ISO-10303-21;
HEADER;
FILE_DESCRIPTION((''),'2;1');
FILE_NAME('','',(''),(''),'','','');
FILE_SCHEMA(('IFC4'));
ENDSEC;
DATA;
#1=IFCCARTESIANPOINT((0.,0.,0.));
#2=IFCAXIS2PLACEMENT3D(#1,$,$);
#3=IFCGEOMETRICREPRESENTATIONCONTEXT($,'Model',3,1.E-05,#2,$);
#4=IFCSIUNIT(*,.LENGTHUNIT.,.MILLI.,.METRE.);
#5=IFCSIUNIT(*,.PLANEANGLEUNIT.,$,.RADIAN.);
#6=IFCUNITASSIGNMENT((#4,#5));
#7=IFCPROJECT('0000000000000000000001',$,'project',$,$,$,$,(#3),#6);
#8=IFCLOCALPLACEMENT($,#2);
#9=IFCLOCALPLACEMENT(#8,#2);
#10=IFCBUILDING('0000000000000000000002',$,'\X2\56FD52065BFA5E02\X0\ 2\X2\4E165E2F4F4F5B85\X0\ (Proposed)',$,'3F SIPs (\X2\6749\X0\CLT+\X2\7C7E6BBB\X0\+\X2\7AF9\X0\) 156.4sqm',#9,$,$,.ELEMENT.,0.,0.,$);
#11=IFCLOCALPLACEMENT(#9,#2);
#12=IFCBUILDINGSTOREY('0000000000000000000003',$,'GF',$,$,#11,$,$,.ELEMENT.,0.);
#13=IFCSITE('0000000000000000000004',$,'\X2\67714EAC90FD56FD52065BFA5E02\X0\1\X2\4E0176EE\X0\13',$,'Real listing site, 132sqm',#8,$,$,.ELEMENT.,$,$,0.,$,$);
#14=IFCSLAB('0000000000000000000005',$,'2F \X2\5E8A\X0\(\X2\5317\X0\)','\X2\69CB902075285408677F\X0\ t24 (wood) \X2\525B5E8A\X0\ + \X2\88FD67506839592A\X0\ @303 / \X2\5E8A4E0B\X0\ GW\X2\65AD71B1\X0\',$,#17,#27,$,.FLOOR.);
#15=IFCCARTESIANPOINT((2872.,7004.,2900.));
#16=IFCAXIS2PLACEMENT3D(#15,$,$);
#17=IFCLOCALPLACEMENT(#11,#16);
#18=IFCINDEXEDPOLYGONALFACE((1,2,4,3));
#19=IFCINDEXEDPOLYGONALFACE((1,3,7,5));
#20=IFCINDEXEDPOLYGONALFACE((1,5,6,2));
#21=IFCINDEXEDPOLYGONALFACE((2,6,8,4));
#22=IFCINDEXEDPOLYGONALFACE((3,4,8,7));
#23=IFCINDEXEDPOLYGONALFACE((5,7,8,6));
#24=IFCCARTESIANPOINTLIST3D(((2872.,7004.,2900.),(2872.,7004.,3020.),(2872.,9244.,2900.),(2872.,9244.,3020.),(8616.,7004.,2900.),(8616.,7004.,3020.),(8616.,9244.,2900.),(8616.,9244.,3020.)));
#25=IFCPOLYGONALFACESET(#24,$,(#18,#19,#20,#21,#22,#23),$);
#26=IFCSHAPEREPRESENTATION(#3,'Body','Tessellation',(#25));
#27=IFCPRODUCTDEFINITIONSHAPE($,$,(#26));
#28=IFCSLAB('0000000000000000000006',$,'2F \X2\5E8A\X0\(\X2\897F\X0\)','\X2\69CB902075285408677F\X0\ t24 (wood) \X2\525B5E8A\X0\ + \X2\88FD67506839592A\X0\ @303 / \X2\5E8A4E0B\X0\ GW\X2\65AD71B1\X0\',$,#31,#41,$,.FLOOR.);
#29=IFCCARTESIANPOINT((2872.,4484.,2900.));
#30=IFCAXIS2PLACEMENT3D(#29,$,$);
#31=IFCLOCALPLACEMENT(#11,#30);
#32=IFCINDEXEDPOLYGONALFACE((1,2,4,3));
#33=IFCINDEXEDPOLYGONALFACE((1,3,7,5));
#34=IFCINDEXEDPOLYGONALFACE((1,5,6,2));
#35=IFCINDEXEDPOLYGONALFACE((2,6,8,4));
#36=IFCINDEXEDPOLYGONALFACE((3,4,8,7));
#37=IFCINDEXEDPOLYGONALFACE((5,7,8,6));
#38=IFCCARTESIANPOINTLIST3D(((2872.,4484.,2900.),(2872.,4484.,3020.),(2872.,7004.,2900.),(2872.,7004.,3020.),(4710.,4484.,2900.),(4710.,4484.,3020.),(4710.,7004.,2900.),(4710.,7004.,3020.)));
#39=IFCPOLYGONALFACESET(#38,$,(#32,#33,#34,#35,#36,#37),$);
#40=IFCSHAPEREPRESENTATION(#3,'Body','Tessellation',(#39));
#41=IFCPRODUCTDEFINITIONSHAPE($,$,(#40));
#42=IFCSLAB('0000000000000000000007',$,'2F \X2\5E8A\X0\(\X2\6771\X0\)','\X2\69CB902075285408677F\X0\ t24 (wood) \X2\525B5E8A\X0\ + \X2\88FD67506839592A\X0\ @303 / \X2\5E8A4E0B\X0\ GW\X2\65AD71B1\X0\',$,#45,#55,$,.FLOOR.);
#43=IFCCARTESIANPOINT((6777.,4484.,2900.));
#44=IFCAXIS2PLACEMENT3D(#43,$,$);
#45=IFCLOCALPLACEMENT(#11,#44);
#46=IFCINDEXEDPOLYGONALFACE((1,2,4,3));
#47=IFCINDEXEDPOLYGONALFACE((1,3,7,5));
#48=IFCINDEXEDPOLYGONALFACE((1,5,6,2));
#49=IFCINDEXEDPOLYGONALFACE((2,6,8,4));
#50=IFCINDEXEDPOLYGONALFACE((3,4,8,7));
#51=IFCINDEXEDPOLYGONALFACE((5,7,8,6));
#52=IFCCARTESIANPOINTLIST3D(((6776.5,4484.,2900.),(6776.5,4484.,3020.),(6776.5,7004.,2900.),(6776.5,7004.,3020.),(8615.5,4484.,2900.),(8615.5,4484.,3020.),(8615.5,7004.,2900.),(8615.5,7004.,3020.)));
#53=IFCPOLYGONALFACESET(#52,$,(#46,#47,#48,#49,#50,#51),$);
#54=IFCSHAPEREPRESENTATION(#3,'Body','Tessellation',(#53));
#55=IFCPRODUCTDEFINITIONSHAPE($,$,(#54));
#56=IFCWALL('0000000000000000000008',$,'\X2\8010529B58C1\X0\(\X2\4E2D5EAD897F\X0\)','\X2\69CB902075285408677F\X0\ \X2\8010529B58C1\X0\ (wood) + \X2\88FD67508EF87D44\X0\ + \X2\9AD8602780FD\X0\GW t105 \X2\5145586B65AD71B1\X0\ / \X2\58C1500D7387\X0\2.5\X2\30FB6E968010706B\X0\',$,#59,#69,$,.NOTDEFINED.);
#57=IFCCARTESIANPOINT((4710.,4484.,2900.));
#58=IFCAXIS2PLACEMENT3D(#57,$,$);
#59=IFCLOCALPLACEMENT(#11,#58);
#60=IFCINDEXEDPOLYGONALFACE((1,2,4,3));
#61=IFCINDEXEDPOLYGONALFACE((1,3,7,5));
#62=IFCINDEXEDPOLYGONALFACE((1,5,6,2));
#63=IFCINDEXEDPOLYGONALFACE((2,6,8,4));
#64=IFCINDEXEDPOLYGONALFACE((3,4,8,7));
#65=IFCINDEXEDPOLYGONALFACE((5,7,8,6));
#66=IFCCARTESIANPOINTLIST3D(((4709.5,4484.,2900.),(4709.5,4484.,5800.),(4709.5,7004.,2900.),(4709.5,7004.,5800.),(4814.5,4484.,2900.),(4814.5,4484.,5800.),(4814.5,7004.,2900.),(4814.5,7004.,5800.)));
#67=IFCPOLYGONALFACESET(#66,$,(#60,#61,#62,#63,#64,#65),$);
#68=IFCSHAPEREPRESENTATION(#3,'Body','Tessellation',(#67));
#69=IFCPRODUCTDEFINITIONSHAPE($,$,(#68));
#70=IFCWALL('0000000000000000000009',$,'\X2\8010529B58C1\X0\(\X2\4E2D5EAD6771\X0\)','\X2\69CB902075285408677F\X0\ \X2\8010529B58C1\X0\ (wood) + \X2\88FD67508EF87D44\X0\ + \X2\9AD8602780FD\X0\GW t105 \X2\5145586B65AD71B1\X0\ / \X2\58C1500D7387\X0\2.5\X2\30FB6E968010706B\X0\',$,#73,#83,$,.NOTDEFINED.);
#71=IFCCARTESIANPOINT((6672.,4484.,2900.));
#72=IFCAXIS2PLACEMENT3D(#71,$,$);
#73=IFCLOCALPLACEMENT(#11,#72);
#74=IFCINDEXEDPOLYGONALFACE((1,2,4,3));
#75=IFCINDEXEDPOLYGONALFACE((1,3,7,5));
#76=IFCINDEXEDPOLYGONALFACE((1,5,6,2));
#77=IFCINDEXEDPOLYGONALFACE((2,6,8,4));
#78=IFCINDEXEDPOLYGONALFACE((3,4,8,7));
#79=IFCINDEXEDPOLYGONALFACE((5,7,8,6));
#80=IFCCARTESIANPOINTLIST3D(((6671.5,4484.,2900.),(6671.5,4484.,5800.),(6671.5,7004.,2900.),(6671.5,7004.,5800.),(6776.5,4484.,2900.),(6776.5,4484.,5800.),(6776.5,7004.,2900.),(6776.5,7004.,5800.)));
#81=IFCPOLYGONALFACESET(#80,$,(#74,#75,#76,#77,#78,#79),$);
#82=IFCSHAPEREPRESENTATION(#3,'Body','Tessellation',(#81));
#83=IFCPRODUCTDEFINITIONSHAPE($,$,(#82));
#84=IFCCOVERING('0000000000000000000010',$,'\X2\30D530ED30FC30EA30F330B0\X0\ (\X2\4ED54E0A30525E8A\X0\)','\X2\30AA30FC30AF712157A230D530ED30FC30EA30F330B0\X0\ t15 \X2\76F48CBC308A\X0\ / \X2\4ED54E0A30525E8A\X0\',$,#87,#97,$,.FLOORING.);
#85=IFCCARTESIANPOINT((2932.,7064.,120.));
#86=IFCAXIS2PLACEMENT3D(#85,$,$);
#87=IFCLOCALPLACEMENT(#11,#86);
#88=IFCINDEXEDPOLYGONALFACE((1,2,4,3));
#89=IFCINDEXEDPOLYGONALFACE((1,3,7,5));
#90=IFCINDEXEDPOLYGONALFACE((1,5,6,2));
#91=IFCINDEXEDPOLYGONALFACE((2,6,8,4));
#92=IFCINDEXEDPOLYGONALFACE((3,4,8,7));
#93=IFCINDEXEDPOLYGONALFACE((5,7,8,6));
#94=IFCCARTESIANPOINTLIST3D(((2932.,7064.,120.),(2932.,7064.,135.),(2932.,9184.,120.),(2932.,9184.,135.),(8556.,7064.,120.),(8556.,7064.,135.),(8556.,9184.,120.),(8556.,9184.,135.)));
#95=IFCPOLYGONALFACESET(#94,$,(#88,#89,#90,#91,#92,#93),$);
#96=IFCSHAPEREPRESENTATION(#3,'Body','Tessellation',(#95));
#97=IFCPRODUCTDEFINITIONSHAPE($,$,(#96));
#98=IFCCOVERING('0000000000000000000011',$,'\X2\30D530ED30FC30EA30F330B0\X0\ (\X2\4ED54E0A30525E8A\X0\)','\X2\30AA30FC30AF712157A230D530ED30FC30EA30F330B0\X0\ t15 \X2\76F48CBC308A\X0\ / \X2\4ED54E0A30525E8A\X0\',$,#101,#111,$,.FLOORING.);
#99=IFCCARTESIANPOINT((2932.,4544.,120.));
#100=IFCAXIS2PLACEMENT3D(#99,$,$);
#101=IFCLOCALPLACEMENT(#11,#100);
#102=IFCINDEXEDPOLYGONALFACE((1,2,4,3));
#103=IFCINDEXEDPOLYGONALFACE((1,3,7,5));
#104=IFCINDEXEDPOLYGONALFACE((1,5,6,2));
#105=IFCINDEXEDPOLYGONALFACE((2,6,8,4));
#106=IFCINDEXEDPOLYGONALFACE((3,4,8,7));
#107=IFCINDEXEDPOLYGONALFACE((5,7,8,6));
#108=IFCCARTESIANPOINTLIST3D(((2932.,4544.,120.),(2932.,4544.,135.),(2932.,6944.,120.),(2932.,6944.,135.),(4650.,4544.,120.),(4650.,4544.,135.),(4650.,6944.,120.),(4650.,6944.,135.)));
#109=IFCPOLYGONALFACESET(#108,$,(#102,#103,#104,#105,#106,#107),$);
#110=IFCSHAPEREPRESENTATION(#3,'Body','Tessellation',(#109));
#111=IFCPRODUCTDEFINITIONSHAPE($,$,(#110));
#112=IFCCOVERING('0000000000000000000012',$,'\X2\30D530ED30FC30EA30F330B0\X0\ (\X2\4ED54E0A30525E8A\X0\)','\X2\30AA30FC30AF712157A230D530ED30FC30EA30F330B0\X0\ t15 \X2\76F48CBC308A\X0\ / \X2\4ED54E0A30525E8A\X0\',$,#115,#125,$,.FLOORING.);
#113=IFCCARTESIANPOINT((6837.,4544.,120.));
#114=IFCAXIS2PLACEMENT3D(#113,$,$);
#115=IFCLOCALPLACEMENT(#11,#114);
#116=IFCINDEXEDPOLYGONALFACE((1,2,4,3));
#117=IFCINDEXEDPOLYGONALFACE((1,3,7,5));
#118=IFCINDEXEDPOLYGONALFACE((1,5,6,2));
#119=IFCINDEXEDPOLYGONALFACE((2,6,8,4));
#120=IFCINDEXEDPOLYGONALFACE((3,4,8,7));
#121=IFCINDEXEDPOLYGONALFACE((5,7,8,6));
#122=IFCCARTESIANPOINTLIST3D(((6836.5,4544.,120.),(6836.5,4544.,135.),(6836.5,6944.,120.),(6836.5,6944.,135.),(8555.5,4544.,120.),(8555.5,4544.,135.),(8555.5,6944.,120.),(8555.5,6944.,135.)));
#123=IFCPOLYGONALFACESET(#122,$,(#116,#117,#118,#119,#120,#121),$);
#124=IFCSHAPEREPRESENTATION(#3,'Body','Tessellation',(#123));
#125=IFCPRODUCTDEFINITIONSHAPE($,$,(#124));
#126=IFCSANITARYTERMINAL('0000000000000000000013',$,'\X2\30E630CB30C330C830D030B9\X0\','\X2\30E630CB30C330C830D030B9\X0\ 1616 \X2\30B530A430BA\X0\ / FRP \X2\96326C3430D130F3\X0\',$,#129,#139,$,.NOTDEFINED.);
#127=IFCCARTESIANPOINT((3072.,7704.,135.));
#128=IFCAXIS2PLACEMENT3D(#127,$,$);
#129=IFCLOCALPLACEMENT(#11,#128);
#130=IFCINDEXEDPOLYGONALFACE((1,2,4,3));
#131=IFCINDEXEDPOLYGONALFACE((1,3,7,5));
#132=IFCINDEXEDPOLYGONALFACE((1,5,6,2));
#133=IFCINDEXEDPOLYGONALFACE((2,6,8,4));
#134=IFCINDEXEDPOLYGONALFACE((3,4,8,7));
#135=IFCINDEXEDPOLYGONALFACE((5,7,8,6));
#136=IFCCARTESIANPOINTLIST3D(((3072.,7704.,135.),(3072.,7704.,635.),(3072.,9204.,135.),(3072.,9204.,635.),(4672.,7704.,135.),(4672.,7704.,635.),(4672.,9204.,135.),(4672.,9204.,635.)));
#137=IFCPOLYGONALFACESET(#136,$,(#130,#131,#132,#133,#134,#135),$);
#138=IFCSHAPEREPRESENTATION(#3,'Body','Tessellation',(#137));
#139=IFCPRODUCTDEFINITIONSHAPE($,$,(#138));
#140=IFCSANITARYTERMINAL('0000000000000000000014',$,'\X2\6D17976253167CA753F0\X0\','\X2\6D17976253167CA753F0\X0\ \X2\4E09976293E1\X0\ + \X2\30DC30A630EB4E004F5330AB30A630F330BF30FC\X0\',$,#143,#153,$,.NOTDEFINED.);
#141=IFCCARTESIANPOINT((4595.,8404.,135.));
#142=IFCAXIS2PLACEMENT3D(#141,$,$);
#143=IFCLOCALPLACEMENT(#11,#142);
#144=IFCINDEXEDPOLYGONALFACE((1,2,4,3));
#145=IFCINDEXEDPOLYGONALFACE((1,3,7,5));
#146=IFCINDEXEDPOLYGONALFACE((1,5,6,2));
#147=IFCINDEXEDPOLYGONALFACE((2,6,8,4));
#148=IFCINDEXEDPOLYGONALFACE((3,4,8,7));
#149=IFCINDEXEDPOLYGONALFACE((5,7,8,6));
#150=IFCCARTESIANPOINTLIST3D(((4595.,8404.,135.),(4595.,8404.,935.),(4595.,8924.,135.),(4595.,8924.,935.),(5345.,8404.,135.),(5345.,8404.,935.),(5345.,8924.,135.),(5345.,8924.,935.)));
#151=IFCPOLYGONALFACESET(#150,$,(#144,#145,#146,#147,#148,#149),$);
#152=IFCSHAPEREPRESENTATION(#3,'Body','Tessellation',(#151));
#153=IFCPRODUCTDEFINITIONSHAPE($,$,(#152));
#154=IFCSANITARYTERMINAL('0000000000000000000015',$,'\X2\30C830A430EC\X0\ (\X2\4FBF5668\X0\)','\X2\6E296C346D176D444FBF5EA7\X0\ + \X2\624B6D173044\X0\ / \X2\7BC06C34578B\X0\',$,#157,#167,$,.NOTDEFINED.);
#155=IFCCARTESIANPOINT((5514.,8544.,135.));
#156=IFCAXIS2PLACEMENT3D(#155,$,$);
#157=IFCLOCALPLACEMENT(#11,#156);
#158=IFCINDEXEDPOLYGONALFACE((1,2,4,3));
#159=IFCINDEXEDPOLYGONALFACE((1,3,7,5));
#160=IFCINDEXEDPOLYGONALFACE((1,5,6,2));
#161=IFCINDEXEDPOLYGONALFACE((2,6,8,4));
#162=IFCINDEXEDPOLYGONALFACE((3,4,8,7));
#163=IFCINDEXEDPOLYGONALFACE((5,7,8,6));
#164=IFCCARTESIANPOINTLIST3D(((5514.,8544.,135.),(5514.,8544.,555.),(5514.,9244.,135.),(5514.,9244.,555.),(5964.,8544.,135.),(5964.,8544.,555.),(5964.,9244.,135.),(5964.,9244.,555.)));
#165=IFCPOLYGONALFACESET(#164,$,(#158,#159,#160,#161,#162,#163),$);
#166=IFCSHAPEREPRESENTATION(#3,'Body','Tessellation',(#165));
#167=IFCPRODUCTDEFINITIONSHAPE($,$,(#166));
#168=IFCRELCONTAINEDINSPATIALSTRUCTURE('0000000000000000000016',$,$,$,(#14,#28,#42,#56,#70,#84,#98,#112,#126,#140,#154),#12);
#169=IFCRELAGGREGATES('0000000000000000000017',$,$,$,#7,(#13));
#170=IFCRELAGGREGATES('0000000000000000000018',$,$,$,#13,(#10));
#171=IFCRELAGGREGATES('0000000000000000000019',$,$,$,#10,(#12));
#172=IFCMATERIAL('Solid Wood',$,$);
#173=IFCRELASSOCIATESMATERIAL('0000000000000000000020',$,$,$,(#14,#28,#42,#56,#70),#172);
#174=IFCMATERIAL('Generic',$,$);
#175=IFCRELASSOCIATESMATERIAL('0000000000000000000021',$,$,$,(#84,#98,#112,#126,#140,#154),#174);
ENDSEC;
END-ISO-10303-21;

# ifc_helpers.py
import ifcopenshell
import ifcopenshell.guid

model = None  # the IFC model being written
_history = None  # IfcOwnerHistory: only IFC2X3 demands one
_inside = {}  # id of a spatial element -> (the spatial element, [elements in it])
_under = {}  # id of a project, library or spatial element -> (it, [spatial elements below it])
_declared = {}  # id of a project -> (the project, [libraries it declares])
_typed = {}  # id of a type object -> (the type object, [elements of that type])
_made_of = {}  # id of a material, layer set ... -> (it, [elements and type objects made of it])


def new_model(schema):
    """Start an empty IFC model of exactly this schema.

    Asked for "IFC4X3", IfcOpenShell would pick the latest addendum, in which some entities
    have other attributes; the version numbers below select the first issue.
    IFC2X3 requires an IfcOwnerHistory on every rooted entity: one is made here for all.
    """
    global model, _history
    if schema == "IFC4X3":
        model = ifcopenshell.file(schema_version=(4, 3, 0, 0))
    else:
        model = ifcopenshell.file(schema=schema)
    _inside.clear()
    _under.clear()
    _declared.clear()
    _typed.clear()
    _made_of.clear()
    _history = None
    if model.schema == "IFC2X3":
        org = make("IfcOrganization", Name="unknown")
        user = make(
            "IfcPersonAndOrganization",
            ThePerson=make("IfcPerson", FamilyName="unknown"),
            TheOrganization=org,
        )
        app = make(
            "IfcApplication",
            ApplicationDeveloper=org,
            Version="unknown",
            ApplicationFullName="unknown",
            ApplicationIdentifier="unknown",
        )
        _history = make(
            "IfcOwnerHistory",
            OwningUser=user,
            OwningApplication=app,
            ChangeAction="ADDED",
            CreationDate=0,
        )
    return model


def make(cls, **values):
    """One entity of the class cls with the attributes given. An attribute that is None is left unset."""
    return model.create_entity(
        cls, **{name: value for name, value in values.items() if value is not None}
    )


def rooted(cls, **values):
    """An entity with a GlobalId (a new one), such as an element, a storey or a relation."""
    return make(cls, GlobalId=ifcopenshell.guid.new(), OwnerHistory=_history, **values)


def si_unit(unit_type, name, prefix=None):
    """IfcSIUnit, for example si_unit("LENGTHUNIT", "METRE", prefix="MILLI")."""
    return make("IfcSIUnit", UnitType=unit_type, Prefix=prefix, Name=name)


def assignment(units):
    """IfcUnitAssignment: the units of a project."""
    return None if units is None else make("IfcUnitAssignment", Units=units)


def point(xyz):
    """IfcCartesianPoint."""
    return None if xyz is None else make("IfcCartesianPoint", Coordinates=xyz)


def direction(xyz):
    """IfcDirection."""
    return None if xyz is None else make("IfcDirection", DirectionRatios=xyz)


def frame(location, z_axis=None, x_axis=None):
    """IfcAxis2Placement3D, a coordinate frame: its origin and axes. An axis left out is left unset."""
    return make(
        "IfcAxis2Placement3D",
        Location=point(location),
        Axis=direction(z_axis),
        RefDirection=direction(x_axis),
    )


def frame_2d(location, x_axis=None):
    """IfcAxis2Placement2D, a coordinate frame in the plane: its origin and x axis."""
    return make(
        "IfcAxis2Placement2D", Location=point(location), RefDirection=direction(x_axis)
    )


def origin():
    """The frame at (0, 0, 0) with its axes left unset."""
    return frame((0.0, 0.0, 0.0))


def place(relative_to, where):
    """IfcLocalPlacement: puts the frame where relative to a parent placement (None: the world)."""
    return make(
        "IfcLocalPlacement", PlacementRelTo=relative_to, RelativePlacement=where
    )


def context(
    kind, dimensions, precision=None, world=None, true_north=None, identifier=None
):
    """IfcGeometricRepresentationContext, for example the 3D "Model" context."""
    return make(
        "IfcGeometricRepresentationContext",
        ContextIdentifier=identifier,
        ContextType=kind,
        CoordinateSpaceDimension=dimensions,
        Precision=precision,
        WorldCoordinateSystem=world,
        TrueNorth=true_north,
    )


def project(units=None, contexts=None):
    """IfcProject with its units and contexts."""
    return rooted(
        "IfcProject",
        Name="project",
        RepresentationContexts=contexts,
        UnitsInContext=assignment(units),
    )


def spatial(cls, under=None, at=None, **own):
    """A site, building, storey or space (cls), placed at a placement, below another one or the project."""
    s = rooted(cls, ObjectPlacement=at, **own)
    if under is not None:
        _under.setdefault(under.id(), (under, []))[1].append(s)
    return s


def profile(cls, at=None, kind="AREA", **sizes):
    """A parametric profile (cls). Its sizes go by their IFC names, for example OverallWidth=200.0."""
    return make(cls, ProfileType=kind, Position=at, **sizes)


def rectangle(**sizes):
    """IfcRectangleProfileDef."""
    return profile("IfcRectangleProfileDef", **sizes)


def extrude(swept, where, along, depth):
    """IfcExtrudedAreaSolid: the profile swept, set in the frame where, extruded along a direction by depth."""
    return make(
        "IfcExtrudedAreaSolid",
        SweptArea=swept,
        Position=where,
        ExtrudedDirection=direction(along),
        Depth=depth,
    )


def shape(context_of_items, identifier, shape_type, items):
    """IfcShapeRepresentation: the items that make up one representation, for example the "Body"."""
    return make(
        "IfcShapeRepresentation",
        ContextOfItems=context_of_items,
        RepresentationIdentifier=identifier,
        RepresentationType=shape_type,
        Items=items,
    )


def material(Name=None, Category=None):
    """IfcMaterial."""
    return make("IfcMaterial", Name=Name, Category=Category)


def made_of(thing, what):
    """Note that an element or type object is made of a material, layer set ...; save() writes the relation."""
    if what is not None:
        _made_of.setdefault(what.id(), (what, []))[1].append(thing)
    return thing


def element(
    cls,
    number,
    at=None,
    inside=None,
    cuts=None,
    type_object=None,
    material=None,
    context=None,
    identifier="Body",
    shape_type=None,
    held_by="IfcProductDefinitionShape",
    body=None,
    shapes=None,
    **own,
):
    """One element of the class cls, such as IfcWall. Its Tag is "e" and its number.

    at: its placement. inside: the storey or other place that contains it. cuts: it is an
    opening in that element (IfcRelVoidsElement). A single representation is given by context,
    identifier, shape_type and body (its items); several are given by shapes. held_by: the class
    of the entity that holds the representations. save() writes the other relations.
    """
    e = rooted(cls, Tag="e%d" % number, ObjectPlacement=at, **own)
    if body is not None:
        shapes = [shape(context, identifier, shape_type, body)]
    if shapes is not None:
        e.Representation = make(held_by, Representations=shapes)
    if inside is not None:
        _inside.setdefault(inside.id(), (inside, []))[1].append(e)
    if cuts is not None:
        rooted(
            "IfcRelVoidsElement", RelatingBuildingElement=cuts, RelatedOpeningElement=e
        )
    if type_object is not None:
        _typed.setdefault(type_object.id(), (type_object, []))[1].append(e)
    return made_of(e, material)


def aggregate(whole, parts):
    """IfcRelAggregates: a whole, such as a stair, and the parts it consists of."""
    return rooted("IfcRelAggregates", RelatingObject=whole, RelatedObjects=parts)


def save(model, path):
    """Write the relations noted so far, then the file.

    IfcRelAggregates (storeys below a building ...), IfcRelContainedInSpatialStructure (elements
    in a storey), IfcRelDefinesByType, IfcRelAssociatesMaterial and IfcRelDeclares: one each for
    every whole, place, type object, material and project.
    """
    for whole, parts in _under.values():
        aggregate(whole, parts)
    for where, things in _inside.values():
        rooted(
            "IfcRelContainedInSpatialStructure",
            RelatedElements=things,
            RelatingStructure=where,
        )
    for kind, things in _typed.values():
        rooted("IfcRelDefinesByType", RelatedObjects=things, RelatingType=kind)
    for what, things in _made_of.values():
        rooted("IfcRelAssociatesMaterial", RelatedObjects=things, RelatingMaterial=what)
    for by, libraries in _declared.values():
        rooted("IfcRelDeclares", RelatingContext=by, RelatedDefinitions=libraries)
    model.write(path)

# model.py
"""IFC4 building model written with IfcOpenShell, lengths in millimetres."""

from ifc_helpers import new_model, si_unit, frame, frame_2d, origin, place, context, project, spatial, rectangle, extrude, material, element, save


model = new_model("IFC4")

# Units and contexts
model_context = context("Model", 3, precision=1e-05, world=origin())
ifc_project = project(units=[si_unit("LENGTHUNIT", "METRE", prefix="MILLI"), si_unit("PLANEANGLEUNIT", "RADIAN")], contexts=[model_context])

# Site, building, storey
site_placement = place(None, origin())
site = spatial("IfcSite", under=ifc_project, at=site_placement, Name="東京都国分寺市1丁目13", ObjectType="Real listing site, 132sqm", CompositionType="ELEMENT", RefElevation=0.0)
building_placement = place(site_placement, origin())
building = spatial("IfcBuilding", under=site, at=building_placement, Name="国分寺市 2世帯住宅 (Proposed)", ObjectType="3F SIPs (杉CLT+籾殻+竹) 156.4sqm", CompositionType="ELEMENT", ElevationOfRefHeight=0.0, ElevationOfTerrain=0.0)
storey_placement = place(building_placement, origin())
storey = spatial("IfcBuildingStorey", under=building, at=storey_placement, Name="GF", CompositionType="ELEMENT", Elevation=0.0)

# Slabs
ifc_material_1 = material(Name="Solid Wood")
slab_1_placement = place(storey_placement, frame((2872.0, 7004.0, 2900.0)))
element("IfcSlab", 1, at=slab_1_placement, inside=storey, material=ifc_material_1, Name="2F 床(北)", Description="構造用合板 t24 (wood) 剛床 + 製材根太 @303 / 床下 GW断熱", PredefinedType="FLOOR", context=model_context, shape_type="SweptSolid", body=[
    extrude(rectangle(XDim=5744.0, YDim=2240.0, at=frame_2d((2872.0, 1120.0))), frame((2872.0, 7004.0, 2900.0)), (0.0, 0.0, 1.0), 120.0),
])
slab_2_placement = place(storey_placement, frame((2872.0, 4484.0, 2900.0)))
element("IfcSlab", 2, at=slab_2_placement, inside=storey, material=ifc_material_1, Name="2F 床(西)", Description="構造用合板 t24 (wood) 剛床 + 製材根太 @303 / 床下 GW断熱", PredefinedType="FLOOR", context=model_context, shape_type="SweptSolid", body=[
    extrude(rectangle(XDim=1838.0, YDim=2520.0, at=frame_2d((919.0, 1260.0))), frame((2872.0, 4484.0, 2900.0)), (0.0, 0.0, 1.0), 120.0),
])
slab_3_placement = place(storey_placement, frame((6777.0, 4484.0, 2900.0)))
element("IfcSlab", 3, at=slab_3_placement, inside=storey, material=ifc_material_1, Name="2F 床(東)", Description="構造用合板 t24 (wood) 剛床 + 製材根太 @303 / 床下 GW断熱", PredefinedType="FLOOR", context=model_context, shape_type="SweptSolid", body=[
    extrude(rectangle(XDim=1839.0, YDim=2520.0, at=frame_2d((919.0, 1260.0))), frame((6777.0, 4484.0, 2900.0)), (0.0, 0.0, 1.0), 120.0),
])

# Walls
wall_1_placement = place(storey_placement, frame((4710.0, 4484.0, 2900.0)))
element("IfcWall", 4, at=wall_1_placement, inside=storey, material=ifc_material_1, Name="耐力壁(中庭西)", Description="構造用合板 耐力壁 (wood) + 製材軸組 + 高性能GW t105 充填断熱 / 壁倍率2.5・準耐火", PredefinedType="NOTDEFINED", context=model_context, shape_type="SweptSolid", body=[
    extrude(rectangle(XDim=105.0, YDim=2520.0, at=frame_2d((52.0, 1260.0))), frame((4710.0, 4484.0, 2900.0)), (0.0, 0.0, 1.0), 2900.0),
])
wall_2_placement = place(storey_placement, frame((6672.0, 4484.0, 2900.0)))
element("IfcWall", 5, at=wall_2_placement, inside=storey, material=ifc_material_1, Name="耐力壁(中庭東)", Description="構造用合板 耐力壁 (wood) + 製材軸組 + 高性能GW t105 充填断熱 / 壁倍率2.5・準耐火", PredefinedType="NOTDEFINED", context=model_context, shape_type="SweptSolid", body=[
    extrude(rectangle(XDim=105.0, YDim=2520.0, at=frame_2d((52.0, 1260.0))), frame((6672.0, 4484.0, 2900.0)), (0.0, 0.0, 1.0), 2900.0),
])

# Coverings
ifc_material_2 = material(Name="Generic")
covering_1_placement = place(storey_placement, frame((2932.0, 7064.0, 120.0)))
element("IfcCovering", 6, at=covering_1_placement, inside=storey, material=ifc_material_2, Name="フローリング (仕上げ床)", Description="オーク無垢フローリング t15 直貼り / 仕上げ床", PredefinedType="FLOORING", context=model_context, shape_type="SweptSolid", body=[
    extrude(rectangle(XDim=5624.0, YDim=2120.0, at=frame_2d((2812.0, 1060.0))), frame((2932.0, 7064.0, 120.0)), (0.0, 0.0, 1.0), 15.0),
])
covering_2_placement = place(storey_placement, frame((2932.0, 4544.0, 120.0)))
element("IfcCovering", 7, at=covering_2_placement, inside=storey, material=ifc_material_2, Name="フローリング (仕上げ床)", Description="オーク無垢フローリング t15 直貼り / 仕上げ床", PredefinedType="FLOORING", context=model_context, shape_type="SweptSolid", body=[
    extrude(rectangle(XDim=1718.0, YDim=2400.0, at=frame_2d((859.0, 1200.0))), frame((2932.0, 4544.0, 120.0)), (0.0, 0.0, 1.0), 15.0),
])
covering_3_placement = place(storey_placement, frame((6837.0, 4544.0, 120.0)))
element("IfcCovering", 8, at=covering_3_placement, inside=storey, material=ifc_material_2, Name="フローリング (仕上げ床)", Description="オーク無垢フローリング t15 直貼り / 仕上げ床", PredefinedType="FLOORING", context=model_context, shape_type="SweptSolid", body=[
    extrude(rectangle(XDim=1719.0, YDim=2400.0, at=frame_2d((859.0, 1200.0))), frame((6837.0, 4544.0, 120.0)), (0.0, 0.0, 1.0), 15.0),
])

# Sanitary terminals
sanitary_terminal_1_placement = place(storey_placement, frame((3072.0, 7704.0, 135.0)))
element("IfcSanitaryTerminal", 9, at=sanitary_terminal_1_placement, inside=storey, material=ifc_material_2, Name="ユニットバス", Description="ユニットバス 1616 サイズ / FRP 防水パン", PredefinedType="NOTDEFINED", context=model_context, shape_type="SweptSolid", body=[
    extrude(rectangle(XDim=1600.0, YDim=1500.0, at=frame_2d((800.0, 750.0))), frame((3072.0, 7704.0, 135.0)), (0.0, 0.0, 1.0), 500.0),
])
sanitary_terminal_2_placement = place(storey_placement, frame((4595.0, 8404.0, 135.0)))
element("IfcSanitaryTerminal", 10, at=sanitary_terminal_2_placement, inside=storey, material=ifc_material_2, Name="洗面化粧台", Description="洗面化粧台 三面鏡 + ボウル一体カウンター", PredefinedType="NOTDEFINED", context=model_context, shape_type="SweptSolid", body=[
    extrude(rectangle(XDim=750.0, YDim=520.0, at=frame_2d((375.0, 260.0))), frame((4595.0, 8404.0, 135.0)), (0.0, 0.0, 1.0), 800.0),
])
sanitary_terminal_3_placement = place(storey_placement, frame((5514.0, 8544.0, 135.0)))
element("IfcSanitaryTerminal", 11, at=sanitary_terminal_3_placement, inside=storey, material=ifc_material_2, Name="トイレ (便器)", Description="温水洗浄便座 + 手洗い / 節水型", PredefinedType="NOTDEFINED", context=model_context, shape_type="SweptSolid", body=[
    extrude(rectangle(XDim=450.0, YDim=700.0, at=frame_2d((225.0, 350.0))), frame((5514.0, 8544.0, 135.0)), (0.0, 0.0, 1.0), 420.0),
])

save(model, "model.ifc")
